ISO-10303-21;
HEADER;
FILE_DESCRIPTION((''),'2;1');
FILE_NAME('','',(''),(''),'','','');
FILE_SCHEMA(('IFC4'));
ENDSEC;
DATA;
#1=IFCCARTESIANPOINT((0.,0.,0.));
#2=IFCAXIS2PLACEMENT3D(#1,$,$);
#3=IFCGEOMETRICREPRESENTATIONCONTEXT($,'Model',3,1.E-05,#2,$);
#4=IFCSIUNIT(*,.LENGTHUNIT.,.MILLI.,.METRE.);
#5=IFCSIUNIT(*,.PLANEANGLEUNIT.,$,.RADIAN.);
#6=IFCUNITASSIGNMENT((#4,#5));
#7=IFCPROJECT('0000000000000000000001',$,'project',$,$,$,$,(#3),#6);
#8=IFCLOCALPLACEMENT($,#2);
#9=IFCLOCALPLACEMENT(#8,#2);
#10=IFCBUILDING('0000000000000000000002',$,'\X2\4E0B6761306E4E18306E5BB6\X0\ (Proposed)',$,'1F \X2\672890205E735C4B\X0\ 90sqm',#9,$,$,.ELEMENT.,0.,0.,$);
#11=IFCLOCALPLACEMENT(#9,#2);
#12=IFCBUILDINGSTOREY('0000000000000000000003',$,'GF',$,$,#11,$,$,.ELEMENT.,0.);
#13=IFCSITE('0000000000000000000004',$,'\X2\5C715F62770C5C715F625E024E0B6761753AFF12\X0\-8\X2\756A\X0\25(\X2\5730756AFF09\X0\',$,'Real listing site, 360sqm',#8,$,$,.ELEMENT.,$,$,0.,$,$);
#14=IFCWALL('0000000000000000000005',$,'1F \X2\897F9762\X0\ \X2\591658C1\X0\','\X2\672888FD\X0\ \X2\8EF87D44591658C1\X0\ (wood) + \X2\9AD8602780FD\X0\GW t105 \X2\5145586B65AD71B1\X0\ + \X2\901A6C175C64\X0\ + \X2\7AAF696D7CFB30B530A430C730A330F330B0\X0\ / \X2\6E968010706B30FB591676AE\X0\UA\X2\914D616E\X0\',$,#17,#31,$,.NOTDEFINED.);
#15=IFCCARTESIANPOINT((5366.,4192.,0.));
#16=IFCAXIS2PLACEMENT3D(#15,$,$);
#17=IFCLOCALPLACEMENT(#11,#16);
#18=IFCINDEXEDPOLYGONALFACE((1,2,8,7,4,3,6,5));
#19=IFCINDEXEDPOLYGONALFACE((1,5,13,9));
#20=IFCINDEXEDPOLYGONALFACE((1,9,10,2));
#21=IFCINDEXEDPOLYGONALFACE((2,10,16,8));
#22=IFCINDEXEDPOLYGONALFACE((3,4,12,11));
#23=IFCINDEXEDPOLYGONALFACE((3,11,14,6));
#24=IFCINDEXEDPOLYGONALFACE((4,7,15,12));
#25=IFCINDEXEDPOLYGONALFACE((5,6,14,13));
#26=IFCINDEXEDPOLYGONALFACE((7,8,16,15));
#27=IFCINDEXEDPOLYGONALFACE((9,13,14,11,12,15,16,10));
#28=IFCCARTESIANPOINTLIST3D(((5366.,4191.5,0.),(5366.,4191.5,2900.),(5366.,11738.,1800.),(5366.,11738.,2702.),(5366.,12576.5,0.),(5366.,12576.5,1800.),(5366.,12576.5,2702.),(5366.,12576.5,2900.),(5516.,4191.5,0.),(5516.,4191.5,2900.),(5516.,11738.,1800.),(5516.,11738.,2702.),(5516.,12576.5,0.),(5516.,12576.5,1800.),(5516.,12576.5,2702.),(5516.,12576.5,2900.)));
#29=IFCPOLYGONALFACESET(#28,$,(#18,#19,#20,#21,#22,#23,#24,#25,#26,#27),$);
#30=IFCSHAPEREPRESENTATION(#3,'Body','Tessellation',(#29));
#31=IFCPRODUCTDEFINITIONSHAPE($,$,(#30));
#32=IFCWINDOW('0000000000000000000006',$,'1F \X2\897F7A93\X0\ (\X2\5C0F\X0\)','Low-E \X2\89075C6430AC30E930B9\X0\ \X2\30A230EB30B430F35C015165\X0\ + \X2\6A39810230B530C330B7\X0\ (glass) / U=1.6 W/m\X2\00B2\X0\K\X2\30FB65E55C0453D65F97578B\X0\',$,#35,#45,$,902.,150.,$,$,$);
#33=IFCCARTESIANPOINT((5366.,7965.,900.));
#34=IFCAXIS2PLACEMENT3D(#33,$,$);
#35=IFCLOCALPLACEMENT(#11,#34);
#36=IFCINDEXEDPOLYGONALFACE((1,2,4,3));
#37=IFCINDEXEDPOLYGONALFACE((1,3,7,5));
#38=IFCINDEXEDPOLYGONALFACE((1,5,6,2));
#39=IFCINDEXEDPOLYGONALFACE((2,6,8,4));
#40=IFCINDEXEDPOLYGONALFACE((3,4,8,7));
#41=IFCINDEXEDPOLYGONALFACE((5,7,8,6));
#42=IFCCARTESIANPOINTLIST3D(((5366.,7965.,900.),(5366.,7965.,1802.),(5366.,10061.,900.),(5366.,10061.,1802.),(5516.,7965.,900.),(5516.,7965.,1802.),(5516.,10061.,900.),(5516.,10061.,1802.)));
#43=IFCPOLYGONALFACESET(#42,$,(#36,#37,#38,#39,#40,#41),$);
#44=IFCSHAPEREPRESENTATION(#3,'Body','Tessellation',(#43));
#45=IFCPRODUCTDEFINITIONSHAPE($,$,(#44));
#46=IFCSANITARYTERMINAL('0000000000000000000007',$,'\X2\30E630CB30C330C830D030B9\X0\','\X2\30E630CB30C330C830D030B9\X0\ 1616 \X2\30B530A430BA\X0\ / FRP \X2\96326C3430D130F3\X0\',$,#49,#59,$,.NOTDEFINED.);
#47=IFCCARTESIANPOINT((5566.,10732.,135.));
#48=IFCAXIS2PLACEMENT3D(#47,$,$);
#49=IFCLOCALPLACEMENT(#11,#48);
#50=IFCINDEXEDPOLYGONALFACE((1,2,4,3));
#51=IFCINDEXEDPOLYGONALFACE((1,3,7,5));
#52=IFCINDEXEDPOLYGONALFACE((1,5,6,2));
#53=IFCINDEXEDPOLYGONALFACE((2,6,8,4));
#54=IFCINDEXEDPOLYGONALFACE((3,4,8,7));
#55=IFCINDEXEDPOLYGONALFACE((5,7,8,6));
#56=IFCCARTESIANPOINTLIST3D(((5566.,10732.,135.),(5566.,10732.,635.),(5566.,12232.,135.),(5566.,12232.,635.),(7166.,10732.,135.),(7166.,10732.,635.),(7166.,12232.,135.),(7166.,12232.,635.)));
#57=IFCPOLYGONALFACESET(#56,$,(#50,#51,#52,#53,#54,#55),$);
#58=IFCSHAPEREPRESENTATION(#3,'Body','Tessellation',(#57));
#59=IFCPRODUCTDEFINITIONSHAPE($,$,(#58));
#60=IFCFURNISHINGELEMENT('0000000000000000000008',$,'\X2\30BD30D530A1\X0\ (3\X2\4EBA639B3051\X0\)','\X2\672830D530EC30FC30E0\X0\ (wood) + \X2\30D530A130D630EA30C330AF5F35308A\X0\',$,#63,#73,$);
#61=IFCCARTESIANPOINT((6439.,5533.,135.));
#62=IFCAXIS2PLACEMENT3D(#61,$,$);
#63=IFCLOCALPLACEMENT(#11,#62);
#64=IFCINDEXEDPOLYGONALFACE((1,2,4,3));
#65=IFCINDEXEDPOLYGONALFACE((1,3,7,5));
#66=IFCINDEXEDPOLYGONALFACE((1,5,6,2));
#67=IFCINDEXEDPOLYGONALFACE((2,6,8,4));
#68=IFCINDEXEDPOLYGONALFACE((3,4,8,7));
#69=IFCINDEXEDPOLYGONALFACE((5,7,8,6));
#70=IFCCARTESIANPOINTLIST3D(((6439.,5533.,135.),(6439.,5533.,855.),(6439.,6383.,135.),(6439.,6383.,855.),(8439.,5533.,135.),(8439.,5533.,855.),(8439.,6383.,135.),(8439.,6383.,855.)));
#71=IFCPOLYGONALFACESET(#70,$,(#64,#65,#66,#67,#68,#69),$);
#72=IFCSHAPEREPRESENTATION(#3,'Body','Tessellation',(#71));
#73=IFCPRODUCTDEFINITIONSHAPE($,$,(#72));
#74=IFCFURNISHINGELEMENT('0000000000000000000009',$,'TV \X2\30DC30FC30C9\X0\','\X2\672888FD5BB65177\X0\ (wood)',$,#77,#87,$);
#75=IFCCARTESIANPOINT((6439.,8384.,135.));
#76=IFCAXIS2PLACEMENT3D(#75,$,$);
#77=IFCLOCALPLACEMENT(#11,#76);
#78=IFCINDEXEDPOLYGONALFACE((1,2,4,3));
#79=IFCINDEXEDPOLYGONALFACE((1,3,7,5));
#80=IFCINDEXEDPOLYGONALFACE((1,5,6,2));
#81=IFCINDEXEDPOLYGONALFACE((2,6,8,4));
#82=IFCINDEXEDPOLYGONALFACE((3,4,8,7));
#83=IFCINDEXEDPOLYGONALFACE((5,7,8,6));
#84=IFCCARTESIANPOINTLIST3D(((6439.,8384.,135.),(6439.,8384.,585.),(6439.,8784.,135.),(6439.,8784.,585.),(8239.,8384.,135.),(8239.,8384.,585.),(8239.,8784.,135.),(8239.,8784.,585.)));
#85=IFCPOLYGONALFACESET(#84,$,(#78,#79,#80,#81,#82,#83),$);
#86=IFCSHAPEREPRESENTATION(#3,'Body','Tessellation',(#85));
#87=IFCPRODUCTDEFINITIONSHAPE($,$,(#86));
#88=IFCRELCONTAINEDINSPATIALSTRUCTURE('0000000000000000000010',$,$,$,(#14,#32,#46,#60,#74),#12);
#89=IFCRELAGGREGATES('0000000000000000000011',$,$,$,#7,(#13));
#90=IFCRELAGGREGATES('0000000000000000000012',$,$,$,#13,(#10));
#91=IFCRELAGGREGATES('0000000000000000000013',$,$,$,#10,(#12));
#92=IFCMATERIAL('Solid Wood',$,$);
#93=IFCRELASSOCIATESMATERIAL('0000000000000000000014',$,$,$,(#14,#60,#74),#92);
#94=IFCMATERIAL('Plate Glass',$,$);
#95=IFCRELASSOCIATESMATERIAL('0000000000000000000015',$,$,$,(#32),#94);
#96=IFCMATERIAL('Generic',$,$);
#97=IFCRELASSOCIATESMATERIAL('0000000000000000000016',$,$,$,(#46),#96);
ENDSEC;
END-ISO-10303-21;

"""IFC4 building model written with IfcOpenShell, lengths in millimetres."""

from ifc_helpers import new_model, si_unit, frame, frame_2d, origin, place, context, project, spatial, rectangle, extrude, material, element, fill, save


model = new_model("IFC4")

# Units and contexts
model_context = context("Model", 3, precision=1e-05, world=origin())
ifc_project = project(units=[si_unit("LENGTHUNIT", "METRE", prefix="MILLI"), si_unit("PLANEANGLEUNIT", "RADIAN")], contexts=[model_context])

# Site, building, storey
site_placement = place(None, origin())
site = spatial("IfcSite", under=ifc_project, at=site_placement, Name="山形県山形市下条町２-8番25(地番）", ObjectType="Real listing site, 360sqm", CompositionType="ELEMENT", RefElevation=0.0)
building_placement = place(site_placement, origin())
building = spatial("IfcBuilding", under=site, at=building_placement, Name="下条の丘の家 (Proposed)", ObjectType="1F 木造平屋 90sqm", CompositionType="ELEMENT", ElevationOfRefHeight=0.0, ElevationOfTerrain=0.0)
storey_placement = place(building_placement, origin())
storey = spatial("IfcBuildingStorey", under=building, at=storey_placement, Name="GF", CompositionType="ELEMENT", Elevation=0.0)

# Shared definitions
ifc_material_1 = material(Name="Solid Wood")

# Shared definitions
ifc_material_2 = material(Name="Plate Glass")

# Wall, opening, window
wall_1_placement = place(storey_placement, frame((5366.0, 4192.0, 0.0)))
wall_1 = element("IfcWall", 1, at=wall_1_placement, inside=storey, material=ifc_material_1, Name="1F 西面 外壁", Description="木製 軸組外壁 (wood) + 高性能GW t105 充填断熱 + 通気層 + 窯業系サイディング / 準耐火・外皮UA配慮", PredefinedType="NOTDEFINED", context=model_context, shape_type="SweptSolid", body=[
    extrude(rectangle(XDim=150.0, YDim=8385.0, at=frame_2d((75.0, 4192.0))), frame((5366.0, 4192.0, 0.0)), (0.0, 0.0, 1.0), 2900.0),
])
opening_1_placement = place(storey_placement, frame((5366.0, 7965.0, 900.0)))
opening_1 = element("IfcOpeningElement", 2, at=opening_1_placement, cuts=wall_1, PredefinedType="NOTDEFINED", context=model_context, shape_type="SweptSolid", body=[
    extrude(rectangle(XDim=150.0, YDim=2096.0, at=frame_2d((75.0, 1048.0))), frame((5366.0, 7965.0, 900.0)), (0.0, 0.0, 1.0), 902.0),
])
window_1_placement = place(storey_placement, frame((5366.0, 7965.0, 900.0)))
window_1 = element("IfcWindow", 3, at=window_1_placement, inside=storey, material=ifc_material_2, Name="1F 西窓 (小)", Description="Low-E 複層ガラス アルゴン封入 + 樹脂サッシ (glass) / U=1.6 W/m²K・日射取得型", OverallHeight=902.0, OverallWidth=150.0, context=model_context, shape_type="SweptSolid", body=[
    extrude(rectangle(XDim=150.0, YDim=2096.0, at=frame_2d((75.0, 1048.0))), frame((5366.0, 7965.0, 900.0)), (0.0, 0.0, 1.0), 902.0),
])
fill(opening_1, window_1)

# Shared definitions
ifc_material_3 = material(Name="Generic")

# Sanitary terminal
sanitary_terminal_placement = place(storey_placement, frame((5566.0, 10732.0, 135.0)))
element("IfcSanitaryTerminal", 4, at=sanitary_terminal_placement, inside=storey, material=ifc_material_3, Name="ユニットバス", Description="ユニットバス 1616 サイズ / FRP 防水パン", PredefinedType="NOTDEFINED", context=model_context, shape_type="SweptSolid", body=[
    extrude(rectangle(XDim=1600.0, YDim=1500.0, at=frame_2d((800.0, 750.0))), frame((5566.0, 10732.0, 135.0)), (0.0, 0.0, 1.0), 500.0),
])

# Furnishing elements
furnishing_1_placement = place(storey_placement, frame((6439.0, 5533.0, 135.0)))
element("IfcFurnishingElement", 5, at=furnishing_1_placement, inside=storey, material=ifc_material_1, Name="ソファ (3人掛け)", Description="木フレーム (wood) + ファブリック張り", context=model_context, shape_type="SweptSolid", body=[
    extrude(rectangle(XDim=2000.0, YDim=850.0, at=frame_2d((1000.0, 425.0))), frame((6439.0, 5533.0, 135.0)), (0.0, 0.0, 1.0), 720.0),
])
furnishing_2_placement = place(storey_placement, frame((6439.0, 8384.0, 135.0)))
element("IfcFurnishingElement", 6, at=furnishing_2_placement, inside=storey, material=ifc_material_1, Name="TV ボード", Description="木製家具 (wood)", context=model_context, shape_type="SweptSolid", body=[
    extrude(rectangle(XDim=1800.0, YDim=400.0, at=frame_2d((900.0, 200.0))), frame((6439.0, 8384.0, 135.0)), (0.0, 0.0, 1.0), 450.0),
])

save(model, "model.ifc")
